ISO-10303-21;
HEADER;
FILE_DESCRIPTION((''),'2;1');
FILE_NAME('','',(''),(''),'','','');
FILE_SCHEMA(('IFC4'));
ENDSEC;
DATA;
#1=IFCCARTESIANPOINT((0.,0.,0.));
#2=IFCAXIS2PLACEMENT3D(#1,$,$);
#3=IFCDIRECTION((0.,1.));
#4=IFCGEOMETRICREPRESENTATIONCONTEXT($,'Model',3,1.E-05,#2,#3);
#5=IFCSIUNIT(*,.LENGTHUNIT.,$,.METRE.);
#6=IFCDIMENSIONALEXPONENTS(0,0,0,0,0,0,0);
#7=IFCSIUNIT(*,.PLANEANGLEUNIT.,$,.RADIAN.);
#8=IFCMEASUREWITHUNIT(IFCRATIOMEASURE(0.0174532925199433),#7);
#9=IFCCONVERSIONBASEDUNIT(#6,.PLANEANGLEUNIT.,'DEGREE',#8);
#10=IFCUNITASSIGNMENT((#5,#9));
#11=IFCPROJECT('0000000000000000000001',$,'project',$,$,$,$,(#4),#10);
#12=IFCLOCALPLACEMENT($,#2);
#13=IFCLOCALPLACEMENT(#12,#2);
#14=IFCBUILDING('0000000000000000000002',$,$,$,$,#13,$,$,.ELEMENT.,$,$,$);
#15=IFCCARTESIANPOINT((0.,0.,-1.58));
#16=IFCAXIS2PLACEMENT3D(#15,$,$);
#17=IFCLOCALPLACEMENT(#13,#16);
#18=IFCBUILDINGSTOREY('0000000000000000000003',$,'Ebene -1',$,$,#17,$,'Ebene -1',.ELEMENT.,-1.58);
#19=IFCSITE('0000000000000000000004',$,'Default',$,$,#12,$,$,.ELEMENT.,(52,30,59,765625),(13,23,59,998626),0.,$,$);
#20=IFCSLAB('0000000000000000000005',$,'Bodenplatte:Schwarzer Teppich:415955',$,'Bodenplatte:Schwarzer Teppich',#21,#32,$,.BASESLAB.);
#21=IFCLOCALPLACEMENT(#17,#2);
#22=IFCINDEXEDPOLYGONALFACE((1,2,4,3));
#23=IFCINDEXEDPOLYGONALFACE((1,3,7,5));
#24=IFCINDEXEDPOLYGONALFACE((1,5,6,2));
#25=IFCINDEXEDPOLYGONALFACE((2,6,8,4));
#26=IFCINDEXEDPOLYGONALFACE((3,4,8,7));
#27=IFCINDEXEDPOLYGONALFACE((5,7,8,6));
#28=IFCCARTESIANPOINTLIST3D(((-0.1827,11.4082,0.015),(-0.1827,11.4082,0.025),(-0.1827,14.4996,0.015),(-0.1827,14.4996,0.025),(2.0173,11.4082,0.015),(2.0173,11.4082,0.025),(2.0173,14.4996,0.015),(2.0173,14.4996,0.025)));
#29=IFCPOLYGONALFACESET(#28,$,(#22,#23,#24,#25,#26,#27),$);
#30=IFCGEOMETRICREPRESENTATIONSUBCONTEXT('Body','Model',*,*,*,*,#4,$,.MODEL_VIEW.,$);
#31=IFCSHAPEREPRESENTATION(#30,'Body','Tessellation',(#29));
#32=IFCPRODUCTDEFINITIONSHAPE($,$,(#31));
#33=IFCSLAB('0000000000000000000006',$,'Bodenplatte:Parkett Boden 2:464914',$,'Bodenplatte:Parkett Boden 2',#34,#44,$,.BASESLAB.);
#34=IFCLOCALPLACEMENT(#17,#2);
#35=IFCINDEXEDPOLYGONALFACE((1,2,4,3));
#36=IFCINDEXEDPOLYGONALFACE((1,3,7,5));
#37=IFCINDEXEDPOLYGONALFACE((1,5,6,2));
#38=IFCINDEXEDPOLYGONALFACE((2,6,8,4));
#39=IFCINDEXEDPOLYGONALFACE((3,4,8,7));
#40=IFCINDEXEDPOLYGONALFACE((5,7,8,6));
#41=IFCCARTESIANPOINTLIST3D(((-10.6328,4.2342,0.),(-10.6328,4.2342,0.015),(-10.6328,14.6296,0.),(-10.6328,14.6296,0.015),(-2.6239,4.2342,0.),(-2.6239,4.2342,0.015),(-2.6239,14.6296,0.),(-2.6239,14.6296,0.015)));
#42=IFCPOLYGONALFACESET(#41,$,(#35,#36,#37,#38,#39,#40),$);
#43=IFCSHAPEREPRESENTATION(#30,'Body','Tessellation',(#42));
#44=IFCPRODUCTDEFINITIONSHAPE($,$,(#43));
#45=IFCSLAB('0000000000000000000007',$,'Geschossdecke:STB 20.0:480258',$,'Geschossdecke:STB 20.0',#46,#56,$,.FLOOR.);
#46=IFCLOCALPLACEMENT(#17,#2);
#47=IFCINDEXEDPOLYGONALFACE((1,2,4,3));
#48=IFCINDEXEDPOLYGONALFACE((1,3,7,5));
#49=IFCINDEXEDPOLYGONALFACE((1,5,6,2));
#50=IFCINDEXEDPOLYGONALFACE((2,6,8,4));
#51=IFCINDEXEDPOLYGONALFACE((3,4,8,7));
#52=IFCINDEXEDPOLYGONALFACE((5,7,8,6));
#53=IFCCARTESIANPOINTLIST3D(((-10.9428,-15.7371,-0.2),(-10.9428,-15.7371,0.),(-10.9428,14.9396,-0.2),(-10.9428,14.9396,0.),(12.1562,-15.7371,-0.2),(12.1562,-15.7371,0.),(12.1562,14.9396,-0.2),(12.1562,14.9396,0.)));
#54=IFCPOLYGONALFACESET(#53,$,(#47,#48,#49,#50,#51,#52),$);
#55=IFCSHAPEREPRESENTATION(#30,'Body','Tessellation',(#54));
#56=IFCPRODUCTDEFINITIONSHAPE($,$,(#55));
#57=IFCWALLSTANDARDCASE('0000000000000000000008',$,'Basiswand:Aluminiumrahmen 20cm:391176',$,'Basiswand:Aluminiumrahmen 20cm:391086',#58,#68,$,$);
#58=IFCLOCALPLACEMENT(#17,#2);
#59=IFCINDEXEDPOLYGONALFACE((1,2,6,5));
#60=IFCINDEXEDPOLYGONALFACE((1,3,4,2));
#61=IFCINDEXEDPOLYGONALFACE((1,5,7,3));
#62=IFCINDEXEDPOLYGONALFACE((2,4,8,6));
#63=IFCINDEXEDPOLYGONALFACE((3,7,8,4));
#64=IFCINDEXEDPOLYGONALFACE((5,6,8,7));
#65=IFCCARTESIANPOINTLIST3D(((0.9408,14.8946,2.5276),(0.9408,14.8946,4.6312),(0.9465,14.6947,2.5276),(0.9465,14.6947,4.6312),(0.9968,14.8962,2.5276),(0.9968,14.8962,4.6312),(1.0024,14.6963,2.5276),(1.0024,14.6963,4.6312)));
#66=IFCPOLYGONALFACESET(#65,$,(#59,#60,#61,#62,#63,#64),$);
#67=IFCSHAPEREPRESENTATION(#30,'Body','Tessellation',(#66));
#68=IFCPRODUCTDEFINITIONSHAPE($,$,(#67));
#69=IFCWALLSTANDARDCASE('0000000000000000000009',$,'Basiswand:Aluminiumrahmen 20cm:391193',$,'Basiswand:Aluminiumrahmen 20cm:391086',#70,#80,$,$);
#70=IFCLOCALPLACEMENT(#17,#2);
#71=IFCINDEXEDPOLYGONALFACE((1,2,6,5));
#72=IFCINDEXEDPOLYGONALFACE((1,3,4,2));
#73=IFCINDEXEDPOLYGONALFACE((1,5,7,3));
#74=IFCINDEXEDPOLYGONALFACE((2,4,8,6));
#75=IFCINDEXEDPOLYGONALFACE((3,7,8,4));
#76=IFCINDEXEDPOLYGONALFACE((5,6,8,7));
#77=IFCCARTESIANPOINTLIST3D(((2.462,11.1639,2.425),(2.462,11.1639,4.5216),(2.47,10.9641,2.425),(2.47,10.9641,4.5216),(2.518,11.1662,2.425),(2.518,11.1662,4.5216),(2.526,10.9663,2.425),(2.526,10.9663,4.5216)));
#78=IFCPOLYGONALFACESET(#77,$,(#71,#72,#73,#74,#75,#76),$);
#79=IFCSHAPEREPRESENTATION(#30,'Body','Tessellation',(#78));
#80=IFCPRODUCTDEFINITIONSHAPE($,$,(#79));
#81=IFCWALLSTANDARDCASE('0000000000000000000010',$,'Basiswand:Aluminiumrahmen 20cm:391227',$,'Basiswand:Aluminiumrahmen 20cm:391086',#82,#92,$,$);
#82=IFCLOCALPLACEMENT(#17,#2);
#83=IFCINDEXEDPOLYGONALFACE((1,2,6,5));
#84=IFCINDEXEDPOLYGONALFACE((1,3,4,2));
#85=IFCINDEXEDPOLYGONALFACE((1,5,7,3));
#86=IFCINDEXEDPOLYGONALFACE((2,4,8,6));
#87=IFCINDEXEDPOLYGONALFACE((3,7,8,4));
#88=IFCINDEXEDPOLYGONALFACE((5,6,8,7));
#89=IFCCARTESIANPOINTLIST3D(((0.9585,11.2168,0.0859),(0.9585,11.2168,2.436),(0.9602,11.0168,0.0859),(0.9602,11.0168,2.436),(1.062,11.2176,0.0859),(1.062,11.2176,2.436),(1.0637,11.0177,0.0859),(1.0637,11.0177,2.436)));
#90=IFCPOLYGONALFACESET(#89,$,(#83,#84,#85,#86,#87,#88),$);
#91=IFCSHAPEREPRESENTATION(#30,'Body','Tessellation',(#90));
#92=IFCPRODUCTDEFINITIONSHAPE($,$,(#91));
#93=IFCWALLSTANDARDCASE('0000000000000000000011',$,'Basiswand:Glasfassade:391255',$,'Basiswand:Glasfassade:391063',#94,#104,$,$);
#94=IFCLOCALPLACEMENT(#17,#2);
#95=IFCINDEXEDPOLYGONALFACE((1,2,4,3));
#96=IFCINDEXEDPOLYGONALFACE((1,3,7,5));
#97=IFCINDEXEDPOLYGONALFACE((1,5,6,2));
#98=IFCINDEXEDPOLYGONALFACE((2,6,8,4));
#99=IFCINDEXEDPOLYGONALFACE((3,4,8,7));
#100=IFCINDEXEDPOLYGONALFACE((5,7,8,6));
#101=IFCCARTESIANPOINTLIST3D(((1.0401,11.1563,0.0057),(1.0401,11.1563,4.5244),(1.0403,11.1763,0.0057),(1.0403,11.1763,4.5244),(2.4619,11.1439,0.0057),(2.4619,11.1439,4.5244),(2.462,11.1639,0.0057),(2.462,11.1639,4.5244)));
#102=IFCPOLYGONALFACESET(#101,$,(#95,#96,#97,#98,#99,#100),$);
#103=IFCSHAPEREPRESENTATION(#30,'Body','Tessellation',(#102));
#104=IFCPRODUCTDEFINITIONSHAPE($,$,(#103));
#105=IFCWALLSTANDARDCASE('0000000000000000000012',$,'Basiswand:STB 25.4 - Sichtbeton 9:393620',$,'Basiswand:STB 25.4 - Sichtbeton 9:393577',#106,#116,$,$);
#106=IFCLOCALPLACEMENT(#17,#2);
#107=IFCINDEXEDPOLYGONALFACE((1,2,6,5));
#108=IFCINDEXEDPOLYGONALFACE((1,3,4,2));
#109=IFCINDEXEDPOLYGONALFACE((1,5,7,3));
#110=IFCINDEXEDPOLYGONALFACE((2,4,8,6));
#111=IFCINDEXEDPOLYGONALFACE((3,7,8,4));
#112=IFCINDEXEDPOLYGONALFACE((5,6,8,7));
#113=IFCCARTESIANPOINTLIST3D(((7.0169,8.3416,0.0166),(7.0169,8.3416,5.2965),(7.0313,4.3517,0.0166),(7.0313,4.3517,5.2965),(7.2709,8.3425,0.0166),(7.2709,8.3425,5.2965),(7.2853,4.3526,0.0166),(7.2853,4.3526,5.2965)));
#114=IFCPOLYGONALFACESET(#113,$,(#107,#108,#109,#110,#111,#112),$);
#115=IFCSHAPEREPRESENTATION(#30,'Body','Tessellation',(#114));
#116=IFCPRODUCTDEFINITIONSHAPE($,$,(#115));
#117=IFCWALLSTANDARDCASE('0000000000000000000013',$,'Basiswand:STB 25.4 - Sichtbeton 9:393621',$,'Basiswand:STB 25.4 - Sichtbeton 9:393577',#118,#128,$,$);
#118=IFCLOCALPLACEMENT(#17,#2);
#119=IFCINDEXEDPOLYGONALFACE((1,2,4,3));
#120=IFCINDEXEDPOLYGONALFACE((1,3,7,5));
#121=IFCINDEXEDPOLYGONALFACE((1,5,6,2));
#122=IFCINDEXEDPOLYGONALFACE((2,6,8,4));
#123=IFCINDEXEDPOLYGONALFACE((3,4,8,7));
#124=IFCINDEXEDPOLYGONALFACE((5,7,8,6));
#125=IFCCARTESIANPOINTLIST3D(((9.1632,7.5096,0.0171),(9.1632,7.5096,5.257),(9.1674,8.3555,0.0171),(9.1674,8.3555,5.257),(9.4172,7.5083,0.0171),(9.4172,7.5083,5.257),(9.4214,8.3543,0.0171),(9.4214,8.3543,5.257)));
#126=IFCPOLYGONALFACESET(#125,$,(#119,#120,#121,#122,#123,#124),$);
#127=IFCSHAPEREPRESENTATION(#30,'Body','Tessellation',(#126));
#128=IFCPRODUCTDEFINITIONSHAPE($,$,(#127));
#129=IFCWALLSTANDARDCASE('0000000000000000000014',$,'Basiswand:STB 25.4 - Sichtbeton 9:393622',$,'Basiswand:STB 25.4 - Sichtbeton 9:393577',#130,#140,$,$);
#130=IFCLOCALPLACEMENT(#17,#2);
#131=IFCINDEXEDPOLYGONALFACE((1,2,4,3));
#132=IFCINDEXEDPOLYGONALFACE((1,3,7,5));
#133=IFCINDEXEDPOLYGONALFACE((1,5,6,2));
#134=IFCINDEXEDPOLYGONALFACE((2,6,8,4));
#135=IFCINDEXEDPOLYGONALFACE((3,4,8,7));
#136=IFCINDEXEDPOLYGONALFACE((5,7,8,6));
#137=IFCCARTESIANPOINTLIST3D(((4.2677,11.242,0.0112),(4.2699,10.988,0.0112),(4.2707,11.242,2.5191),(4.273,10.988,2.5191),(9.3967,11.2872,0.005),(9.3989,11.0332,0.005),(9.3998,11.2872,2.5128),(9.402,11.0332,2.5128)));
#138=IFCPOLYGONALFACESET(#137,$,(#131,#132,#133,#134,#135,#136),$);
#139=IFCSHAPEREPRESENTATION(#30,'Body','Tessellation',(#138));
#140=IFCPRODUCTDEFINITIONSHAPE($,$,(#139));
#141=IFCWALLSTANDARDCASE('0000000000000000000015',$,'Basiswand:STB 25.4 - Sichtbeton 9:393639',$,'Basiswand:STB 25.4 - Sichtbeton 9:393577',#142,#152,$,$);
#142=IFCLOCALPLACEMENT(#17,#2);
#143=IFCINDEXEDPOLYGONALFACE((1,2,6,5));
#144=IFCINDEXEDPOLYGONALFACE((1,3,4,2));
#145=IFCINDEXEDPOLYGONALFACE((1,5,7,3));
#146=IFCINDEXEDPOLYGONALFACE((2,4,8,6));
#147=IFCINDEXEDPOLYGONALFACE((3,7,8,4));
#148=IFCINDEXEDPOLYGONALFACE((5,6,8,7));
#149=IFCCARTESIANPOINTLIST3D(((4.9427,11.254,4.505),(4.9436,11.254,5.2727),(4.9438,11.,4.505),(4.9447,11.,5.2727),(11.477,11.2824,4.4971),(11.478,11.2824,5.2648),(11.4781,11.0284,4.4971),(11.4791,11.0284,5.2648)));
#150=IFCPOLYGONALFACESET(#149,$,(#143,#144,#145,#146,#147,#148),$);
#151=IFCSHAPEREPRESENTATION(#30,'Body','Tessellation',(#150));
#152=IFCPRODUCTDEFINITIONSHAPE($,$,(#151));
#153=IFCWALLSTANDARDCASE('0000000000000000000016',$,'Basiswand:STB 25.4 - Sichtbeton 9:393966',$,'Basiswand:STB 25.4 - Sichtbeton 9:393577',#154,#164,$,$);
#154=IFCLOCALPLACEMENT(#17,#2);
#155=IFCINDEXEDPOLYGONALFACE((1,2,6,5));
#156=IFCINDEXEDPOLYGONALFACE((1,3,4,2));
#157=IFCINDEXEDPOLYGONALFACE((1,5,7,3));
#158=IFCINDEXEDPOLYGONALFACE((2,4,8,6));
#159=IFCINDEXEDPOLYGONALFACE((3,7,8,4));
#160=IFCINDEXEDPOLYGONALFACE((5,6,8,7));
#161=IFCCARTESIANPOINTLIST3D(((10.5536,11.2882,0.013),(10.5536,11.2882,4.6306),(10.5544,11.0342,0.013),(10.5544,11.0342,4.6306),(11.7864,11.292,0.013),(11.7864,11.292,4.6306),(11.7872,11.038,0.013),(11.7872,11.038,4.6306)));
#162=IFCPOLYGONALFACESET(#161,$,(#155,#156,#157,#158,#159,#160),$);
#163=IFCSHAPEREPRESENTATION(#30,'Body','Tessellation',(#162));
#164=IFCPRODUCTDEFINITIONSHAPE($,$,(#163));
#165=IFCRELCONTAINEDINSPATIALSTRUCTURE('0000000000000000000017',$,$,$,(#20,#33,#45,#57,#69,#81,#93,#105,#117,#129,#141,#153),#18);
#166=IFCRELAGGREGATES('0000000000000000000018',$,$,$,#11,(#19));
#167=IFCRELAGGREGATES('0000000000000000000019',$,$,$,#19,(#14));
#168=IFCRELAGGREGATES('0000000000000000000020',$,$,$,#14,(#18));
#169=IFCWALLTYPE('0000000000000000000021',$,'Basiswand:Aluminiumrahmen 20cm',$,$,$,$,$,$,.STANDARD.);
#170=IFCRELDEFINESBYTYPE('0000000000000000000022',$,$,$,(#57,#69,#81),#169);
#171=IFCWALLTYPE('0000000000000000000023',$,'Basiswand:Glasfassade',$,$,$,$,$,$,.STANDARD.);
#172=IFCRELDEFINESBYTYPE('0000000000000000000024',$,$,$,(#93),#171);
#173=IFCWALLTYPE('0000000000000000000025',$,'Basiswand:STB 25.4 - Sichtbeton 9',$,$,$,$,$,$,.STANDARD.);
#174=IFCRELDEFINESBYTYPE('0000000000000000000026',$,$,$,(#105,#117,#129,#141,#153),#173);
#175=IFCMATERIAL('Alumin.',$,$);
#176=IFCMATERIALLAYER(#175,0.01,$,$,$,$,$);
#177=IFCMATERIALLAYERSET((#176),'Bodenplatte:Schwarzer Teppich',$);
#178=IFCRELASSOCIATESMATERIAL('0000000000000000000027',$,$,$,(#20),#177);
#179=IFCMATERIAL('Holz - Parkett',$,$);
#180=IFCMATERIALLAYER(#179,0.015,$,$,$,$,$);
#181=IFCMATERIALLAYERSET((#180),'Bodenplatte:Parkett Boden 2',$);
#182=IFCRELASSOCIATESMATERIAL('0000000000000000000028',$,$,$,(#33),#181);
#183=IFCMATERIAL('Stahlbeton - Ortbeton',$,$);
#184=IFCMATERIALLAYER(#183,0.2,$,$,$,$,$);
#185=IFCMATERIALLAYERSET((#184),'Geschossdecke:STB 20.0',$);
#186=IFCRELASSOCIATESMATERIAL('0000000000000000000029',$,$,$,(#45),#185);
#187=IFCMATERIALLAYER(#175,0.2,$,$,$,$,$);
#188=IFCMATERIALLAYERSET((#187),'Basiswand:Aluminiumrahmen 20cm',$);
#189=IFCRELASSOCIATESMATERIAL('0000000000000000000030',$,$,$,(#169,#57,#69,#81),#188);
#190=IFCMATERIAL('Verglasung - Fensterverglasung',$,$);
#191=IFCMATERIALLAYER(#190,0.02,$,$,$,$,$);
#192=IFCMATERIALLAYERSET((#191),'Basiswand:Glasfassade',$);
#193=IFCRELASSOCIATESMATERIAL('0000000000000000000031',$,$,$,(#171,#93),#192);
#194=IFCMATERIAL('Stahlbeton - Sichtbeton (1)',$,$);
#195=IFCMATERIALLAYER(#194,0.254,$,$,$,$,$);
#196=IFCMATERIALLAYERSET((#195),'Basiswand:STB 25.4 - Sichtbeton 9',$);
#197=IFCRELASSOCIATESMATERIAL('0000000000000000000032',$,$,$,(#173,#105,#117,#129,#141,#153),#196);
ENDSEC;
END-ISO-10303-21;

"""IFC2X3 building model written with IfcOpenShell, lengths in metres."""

from ifc_helpers import new_model, entity, si_unit, converted_unit, direction, frame, frame_2d, origin, origin_2d_with_axis, place, context, subcontext, project, spatial, rectangle, extrude, clip, halfspace, material, layer, layer_set, layer_usage, type_object, element, save


model = new_model("IFC2X3")

# Units and contexts
model_context = context("Model", 3, precision=1e-05, world=origin(), true_north=direction((0.0, 1.0)))
body_context = subcontext(model_context, "Body", "Model", "MODEL_VIEW")
ifc_project = project(units=[si_unit("LENGTHUNIT", "METRE"), converted_unit("PLANEANGLEUNIT", "DEGREE", entity("IfcRatioMeasure", 0.0174532925199433), si_unit("PLANEANGLEUNIT", "RADIAN"), dimensions=[0, 0, 0, 0, 0, 0, 0])], contexts=[model_context])

# Site, building, storey
site_placement = place(None, origin())
site = spatial("IfcSite", under=ifc_project, at=site_placement, Name="Default", CompositionType="ELEMENT", RefLatitude=(52, 30, 59, 765625), RefLongitude=(13, 23, 59, 998626), RefElevation=0.0)
building_placement = place(site_placement, origin())
building = spatial("IfcBuilding", under=site, at=building_placement, CompositionType="ELEMENT")
storey_placement = place(building_placement, frame((0.0, 0.0, -1.58)))
storey = spatial("IfcBuildingStorey", under=building, at=storey_placement, Name="Ebene -1", LongName="Ebene -1", CompositionType="ELEMENT", Elevation=-1.58)

# Slabs
ifc_material_1 = material(Name="Alumin.")
ifc_layer_1 = layer(ifc_material_1, 0.01)
ifc_layer_set_1 = layer_set([ifc_layer_1], Name="Bodenplatte:Schwarzer Teppich")
ifc_layer_usage_1 = layer_usage(ifc_layer_set_1, "AXIS3", "POSITIVE", 0.0)
slab_1_placement = place(storey_placement, origin())
element("IfcSlab", 1, at=slab_1_placement, inside=storey, material=ifc_layer_usage_1, Name="Bodenplatte:Schwarzer Teppich:415955", ObjectType="Bodenplatte:Schwarzer Teppich", PredefinedType="BASESLAB", context=body_context, shape_type="SweptSolid", body=[
    extrude(rectangle(XDim=3.0914, YDim=2.2, at=frame_2d((0.0, 0.0), x_axis=(1.0, 0.0))), frame((0.9173, 12.9539, 0.025), z_axis=(0.0, 0.0, -1.0), x_axis=(0.0, 1.0, 0.0)), (0.0, 0.0, 1.0), 0.01),
])
ifc_material_2 = material(Name="Holz - Parkett")
ifc_layer_2 = layer(ifc_material_2, 0.015)
ifc_layer_set_2 = layer_set([ifc_layer_2], Name="Bodenplatte:Parkett Boden 2")
ifc_layer_usage_2 = layer_usage(ifc_layer_set_2, "AXIS3", "POSITIVE", 0.0)
slab_2_placement = place(storey_placement, origin())
element("IfcSlab", 2, at=slab_2_placement, inside=storey, material=ifc_layer_usage_2, Name="Bodenplatte:Parkett Boden 2:464914", ObjectType="Bodenplatte:Parkett Boden 2", PredefinedType="BASESLAB", context=body_context, shape_type="SweptSolid", body=[
    extrude(rectangle(XDim=10.3953, YDim=8.0089, at=frame_2d((0.0, 0.0), x_axis=(1.0, 0.0))), frame((-6.6284, 9.4319, 0.015), z_axis=(0.0, 0.0, -1.0), x_axis=(0.0, 1.0, 0.0)), (0.0, 0.0, 1.0), 0.015),
])
ifc_material_3 = material(Name="Stahlbeton - Ortbeton")
ifc_layer_3 = layer(ifc_material_3, 0.2)
ifc_layer_set_3 = layer_set([ifc_layer_3], Name="Geschossdecke:STB 20.0")
ifc_layer_usage_3 = layer_usage(ifc_layer_set_3, "AXIS3", "POSITIVE", 0.0)
slab_3_placement = place(storey_placement, origin())
element("IfcSlab", 3, at=slab_3_placement, inside=storey, material=ifc_layer_usage_3, Name="Geschossdecke:STB 20.0:480258", ObjectType="Geschossdecke:STB 20.0", PredefinedType="FLOOR", context=body_context, shape_type="SweptSolid", body=[
    extrude(rectangle(XDim=30.6766, YDim=23.099, at=origin_2d_with_axis()), frame((0.6067, -0.3988, 0.0), z_axis=(0.0, 0.0, -1.0), x_axis=(0.0, 1.0, 0.0)), (0.0, 0.0, 1.0), 0.2),
])

# Walls
ifc_layer_4 = layer(ifc_material_1, 0.2)
ifc_layer_set_4 = layer_set([ifc_layer_4], Name="Basiswand:Aluminiumrahmen 20cm")
ifc_layer_usage_4 = layer_usage(ifc_layer_set_4, "AXIS2", "POSITIVE", -0.1)
wall_type_1 = type_object("IfcWallType", Name="Basiswand:Aluminiumrahmen 20cm", PredefinedType="STANDARD", material=ifc_layer_set_4)
wall_1_placement = place(storey_placement, frame((0.9436, 14.7946, 2.5276), z_axis=(0.0, 0.0, 1.0), x_axis=(0.9996, 0.028291, 0.0)))
element("IfcWallStandardCase", 4, at=wall_1_placement, inside=storey, type_object=wall_type_1, material=ifc_layer_usage_4, Name="Basiswand:Aluminiumrahmen 20cm:391176", ObjectType="Basiswand:Aluminiumrahmen 20cm:391086", context=body_context, shape_type="SweptSolid", body=[
    extrude(rectangle(XDim=0.056, YDim=0.2, at=frame_2d((0.028, 0.0), x_axis=(-1.0, 0.0))), origin(), (0.0, 0.0, 1.0), 2.1036),
])
ifc_layer_usage_5 = layer_usage(ifc_layer_set_4, "AXIS2", "POSITIVE", -0.1)
wall_2_placement = place(storey_placement, frame((2.522, 11.0662, 2.425), z_axis=(0.0, 0.0, 1.0), x_axis=(-0.999201, -0.039975, 0.0)))
element("IfcWallStandardCase", 5, at=wall_2_placement, inside=storey, type_object=wall_type_1, material=ifc_layer_usage_5, Name="Basiswand:Aluminiumrahmen 20cm:391193", ObjectType="Basiswand:Aluminiumrahmen 20cm:391086", context=body_context, shape_type="SweptSolid", body=[
    extrude(rectangle(XDim=0.056, YDim=0.2, at=frame_2d((0.028, 0.0), x_axis=(-1.0, 0.0))), origin(), (0.0, 0.0, 1.0), 2.0965),
])
ifc_layer_usage_6 = layer_usage(ifc_layer_set_4, "AXIS2", "POSITIVE", -0.1)
wall_3_placement = place(storey_placement, frame((1.0629, 11.1177, 0.0859), z_axis=(0.0, 0.0, 1.0), x_axis=(-0.999965, -0.008316, 0.0)))
element("IfcWallStandardCase", 6, at=wall_3_placement, inside=storey, type_object=wall_type_1, material=ifc_layer_usage_6, Name="Basiswand:Aluminiumrahmen 20cm:391227", ObjectType="Basiswand:Aluminiumrahmen 20cm:391086", context=body_context, shape_type="SweptSolid", body=[
    extrude(rectangle(XDim=0.1035, YDim=0.2, at=frame_2d((0.0518, 0.0), x_axis=(-1.0, 0.0))), origin(), (0.0, 0.0, 1.0), 2.3501),
])
ifc_material_4 = material(Name="Verglasung - Fensterverglasung")
ifc_layer_5 = layer(ifc_material_4, 0.02)
ifc_layer_set_5 = layer_set([ifc_layer_5], Name="Basiswand:Glasfassade")
ifc_layer_usage_7 = layer_usage(ifc_layer_set_5, "AXIS2", "POSITIVE", -0.01)
wall_type_2 = type_object("IfcWallType", Name="Basiswand:Glasfassade", PredefinedType="STANDARD", material=ifc_layer_set_5)
wall_4_placement = place(storey_placement, frame((2.462, 11.1539, 0.0057), z_axis=(0.0, 0.0, 1.0), x_axis=(-0.999962, 0.008701, 0.0)))
element("IfcWallStandardCase", 7, at=wall_4_placement, inside=storey, type_object=wall_type_2, material=ifc_layer_usage_7, Name="Basiswand:Glasfassade:391255", ObjectType="Basiswand:Glasfassade:391063", context=body_context, shape_type="SweptSolid", body=[
    extrude(rectangle(XDim=1.4218, YDim=0.02, at=frame_2d((0.7109, 0.0), x_axis=(-1.0, 0.0))), origin(), (0.0, 0.0, 1.0), 4.5187),
])
ifc_material_5 = material(Name="Stahlbeton - Sichtbeton (1)")
ifc_layer_6 = layer(ifc_material_5, 0.254)
ifc_layer_set_6 = layer_set([ifc_layer_6], Name="Basiswand:STB 25.4 - Sichtbeton 9")
ifc_layer_usage_8 = layer_usage(ifc_layer_set_6, "AXIS2", "POSITIVE", -0.127)
wall_type_3 = type_object("IfcWallType", Name="Basiswand:STB 25.4 - Sichtbeton 9", PredefinedType="STANDARD", material=ifc_layer_set_6)
wall_5_placement = place(storey_placement, frame((7.1583, 4.3521, 0.0166), z_axis=(0.0, 0.0, 1.0), x_axis=(-0.003617, 0.999993, 0.0)))
element("IfcWallStandardCase", 8, at=wall_5_placement, inside=storey, type_object=wall_type_3, material=ifc_layer_usage_8, Name="Basiswand:STB 25.4 - Sichtbeton 9:393620", ObjectType="Basiswand:STB 25.4 - Sichtbeton 9:393577", context=body_context, shape_type="SweptSolid", body=[
    extrude(rectangle(XDim=3.9899, YDim=0.254, at=frame_2d((1.9949, 0.0), x_axis=(-1.0, 0.0))), origin(), (0.0, 0.0, 1.0), 5.2799),
])
ifc_layer_usage_9 = layer_usage(ifc_layer_set_6, "AXIS2", "POSITIVE", -0.127)
wall_6_placement = place(storey_placement, frame((9.2902, 7.5089, 0.0171), z_axis=(0.0, 0.0, 1.0), x_axis=(0.005002, 0.999987, 0.0)))
element("IfcWallStandardCase", 9, at=wall_6_placement, inside=storey, type_object=wall_type_3, material=ifc_layer_usage_9, Name="Basiswand:STB 25.4 - Sichtbeton 9:393621", ObjectType="Basiswand:STB 25.4 - Sichtbeton 9:393577", context=body_context, shape_type="SweptSolid", body=[
    extrude(rectangle(XDim=0.846, YDim=0.254, at=frame_2d((0.423, 0.0), x_axis=(-1.0, 0.0))), origin(), (0.0, 0.0, 1.0), 5.24),
])
ifc_layer_usage_10 = layer_usage(ifc_layer_set_6, "AXIS2", "POSITIVE", -0.127)
wall_7_placement = place(storey_placement, frame((4.2688, 11.115, 0.005), z_axis=(0.0, 0.0, 1.0), x_axis=(0.999961, 0.008805, 0.0)))
element("IfcWallStandardCase", 10, at=wall_7_placement, inside=storey, type_object=wall_type_3, material=ifc_layer_usage_10, Name="Basiswand:STB 25.4 - Sichtbeton 9:393622", ObjectType="Basiswand:STB 25.4 - Sichtbeton 9:393577", context=body_context, shape_type="Clipping", body=[
    clip(clip(clip(clip(extrude(rectangle(XDim=5.1323, YDim=0.254, at=frame_2d((2.5661, 0.0), x_axis=(-1.0, 0.0))), origin(), (0.0, 0.0, 1.0), 2.5141), halfspace(frame((0.0, -0.127, 0.0062), z_axis=(-0.999999, 0.0, 0.001216), x_axis=(0.0, 1.0, 0.0)), False)), halfspace(frame((5.1292, -0.127, 0.0), z_axis=(-0.001213, 0.0, -0.999999), x_axis=(0.0, 1.0, 0.0)), False)), halfspace(frame((5.1323, -0.127, 2.5078), z_axis=(0.999999, 0.0, -0.001216), x_axis=(0.0, 1.0, 0.0)), False)), halfspace(frame((0.003, -0.127, 2.5141), z_axis=(0.001216, 0.0, 0.999999), x_axis=(0.0, 1.0, 0.0)), False)),
])
ifc_layer_usage_11 = layer_usage(ifc_layer_set_6, "AXIS2", "POSITIVE", -0.127)
wall_8_placement = place(storey_placement, frame((4.9433, 11.127, 4.4971), z_axis=(0.0, 0.0, 1.0), x_axis=(0.999991, 0.004344, 0.0)))
element("IfcWallStandardCase", 11, at=wall_8_placement, inside=storey, type_object=wall_type_3, material=ifc_layer_usage_11, Name="Basiswand:STB 25.4 - Sichtbeton 9:393639", ObjectType="Basiswand:STB 25.4 - Sichtbeton 9:393577", context=body_context, shape_type="Clipping", body=[
    clip(clip(clip(clip(extrude(rectangle(XDim=6.5353, YDim=0.254, at=frame_2d((3.2677, 0.0), x_axis=(-1.0, 0.0))), origin(), (0.0, 0.0, 1.0), 0.7757), halfspace(frame((0.0, -0.127, 0.0079), z_axis=(-0.999999, 0.0, 0.001216), x_axis=(0.0, 1.0, 0.0)), False)), halfspace(frame((6.5344, -0.127, 0.0), z_axis=(-0.001213, 0.0, -0.999999), x_axis=(0.0, 1.0, 0.0)), False)), halfspace(frame((6.5353, -0.127, 0.7677), z_axis=(0.999999, 0.0, -0.001216), x_axis=(0.0, 1.0, 0.0)), False)), halfspace(frame((0.0009, -0.127, 0.7757), z_axis=(0.001216, 0.0, 0.999999), x_axis=(0.0, 1.0, 0.0)), False)),
])
ifc_layer_usage_12 = layer_usage(ifc_layer_set_6, "AXIS2", "POSITIVE", -0.127)
wall_9_placement = place(storey_placement, frame((10.554, 11.1612, 0.013), z_axis=(0.0, 0.0, 1.0), x_axis=(0.999995, 0.003122, 0.0)))
element("IfcWallStandardCase", 12, at=wall_9_placement, inside=storey, type_object=wall_type_3, material=ifc_layer_usage_12, Name="Basiswand:STB 25.4 - Sichtbeton 9:393966", ObjectType="Basiswand:STB 25.4 - Sichtbeton 9:393577", context=body_context, shape_type="SweptSolid", body=[
    extrude(rectangle(XDim=1.2328, YDim=0.254, at=frame_2d((0.6164, 0.0), x_axis=(-1.0, 0.0))), origin(), (0.0, 0.0, 1.0), 4.6176),
])

save(model, "model.ifc")
